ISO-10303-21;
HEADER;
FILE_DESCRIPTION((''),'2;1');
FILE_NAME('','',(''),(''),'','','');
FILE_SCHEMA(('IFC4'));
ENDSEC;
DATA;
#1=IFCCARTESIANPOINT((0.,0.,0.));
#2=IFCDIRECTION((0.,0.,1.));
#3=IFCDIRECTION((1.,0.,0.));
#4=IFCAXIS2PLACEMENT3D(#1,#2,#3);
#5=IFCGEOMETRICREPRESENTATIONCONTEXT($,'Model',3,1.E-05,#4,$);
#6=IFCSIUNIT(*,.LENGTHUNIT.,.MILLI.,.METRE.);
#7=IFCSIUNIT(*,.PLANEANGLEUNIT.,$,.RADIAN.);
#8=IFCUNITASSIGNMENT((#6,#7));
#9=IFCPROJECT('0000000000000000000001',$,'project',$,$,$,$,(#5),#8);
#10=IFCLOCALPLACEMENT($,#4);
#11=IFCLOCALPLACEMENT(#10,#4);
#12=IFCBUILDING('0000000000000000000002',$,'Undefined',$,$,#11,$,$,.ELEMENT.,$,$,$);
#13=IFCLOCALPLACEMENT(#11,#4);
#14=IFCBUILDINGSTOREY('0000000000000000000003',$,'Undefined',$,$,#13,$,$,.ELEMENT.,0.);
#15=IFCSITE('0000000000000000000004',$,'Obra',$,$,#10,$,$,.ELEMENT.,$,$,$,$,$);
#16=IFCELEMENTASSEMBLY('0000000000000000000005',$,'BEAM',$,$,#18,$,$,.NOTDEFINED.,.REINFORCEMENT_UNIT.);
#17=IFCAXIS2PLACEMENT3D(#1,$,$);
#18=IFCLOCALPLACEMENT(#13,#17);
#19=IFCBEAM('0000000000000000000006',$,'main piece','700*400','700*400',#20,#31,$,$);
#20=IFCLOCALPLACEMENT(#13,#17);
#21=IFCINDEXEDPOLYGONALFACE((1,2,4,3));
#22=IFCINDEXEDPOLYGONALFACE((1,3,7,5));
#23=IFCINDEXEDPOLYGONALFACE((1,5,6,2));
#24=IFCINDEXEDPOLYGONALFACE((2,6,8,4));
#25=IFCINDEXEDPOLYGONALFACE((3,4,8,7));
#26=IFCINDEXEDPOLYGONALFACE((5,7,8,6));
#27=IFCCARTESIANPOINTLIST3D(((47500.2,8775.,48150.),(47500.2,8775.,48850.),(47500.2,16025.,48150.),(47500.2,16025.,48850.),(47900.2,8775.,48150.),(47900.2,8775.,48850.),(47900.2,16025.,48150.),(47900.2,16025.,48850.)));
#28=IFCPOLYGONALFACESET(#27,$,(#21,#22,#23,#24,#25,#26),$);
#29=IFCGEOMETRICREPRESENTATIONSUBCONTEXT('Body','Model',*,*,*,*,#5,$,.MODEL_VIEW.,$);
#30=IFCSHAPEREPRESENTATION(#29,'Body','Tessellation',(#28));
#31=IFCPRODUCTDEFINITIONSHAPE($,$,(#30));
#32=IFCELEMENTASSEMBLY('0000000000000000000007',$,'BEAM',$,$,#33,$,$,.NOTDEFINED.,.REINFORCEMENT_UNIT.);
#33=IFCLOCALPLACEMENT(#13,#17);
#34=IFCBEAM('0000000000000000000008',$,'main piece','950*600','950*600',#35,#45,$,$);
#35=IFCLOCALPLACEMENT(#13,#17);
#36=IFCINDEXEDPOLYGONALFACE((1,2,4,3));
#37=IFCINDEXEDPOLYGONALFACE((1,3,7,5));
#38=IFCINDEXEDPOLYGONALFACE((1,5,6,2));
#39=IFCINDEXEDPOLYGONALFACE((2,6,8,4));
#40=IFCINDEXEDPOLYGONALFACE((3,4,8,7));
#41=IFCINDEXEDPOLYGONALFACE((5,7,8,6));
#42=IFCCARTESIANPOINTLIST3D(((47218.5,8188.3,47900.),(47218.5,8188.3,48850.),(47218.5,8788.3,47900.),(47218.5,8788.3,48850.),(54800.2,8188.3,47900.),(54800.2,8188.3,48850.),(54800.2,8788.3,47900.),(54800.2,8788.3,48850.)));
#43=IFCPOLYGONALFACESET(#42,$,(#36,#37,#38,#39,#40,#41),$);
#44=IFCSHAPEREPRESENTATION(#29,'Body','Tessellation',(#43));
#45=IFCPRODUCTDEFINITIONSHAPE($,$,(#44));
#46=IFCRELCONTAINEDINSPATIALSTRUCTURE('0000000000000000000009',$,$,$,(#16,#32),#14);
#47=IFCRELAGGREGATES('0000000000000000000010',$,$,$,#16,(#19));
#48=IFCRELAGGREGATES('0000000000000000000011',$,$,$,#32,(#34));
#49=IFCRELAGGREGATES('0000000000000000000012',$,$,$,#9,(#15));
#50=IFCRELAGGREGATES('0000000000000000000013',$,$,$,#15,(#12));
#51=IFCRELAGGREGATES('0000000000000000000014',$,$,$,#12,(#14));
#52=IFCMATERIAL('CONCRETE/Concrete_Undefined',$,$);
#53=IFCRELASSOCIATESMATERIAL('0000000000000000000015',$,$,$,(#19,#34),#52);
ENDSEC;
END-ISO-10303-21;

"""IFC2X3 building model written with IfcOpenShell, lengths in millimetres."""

from ifc_helpers import new_model, si_unit, frame, origin_with_axes, origin_2d_with_axis, place, context, subcontext, project, spatial, rectangle, extrude, material, element, aggregate, save


model = new_model("IFC2X3")

# Units and contexts
model_context = context("Model", 3, precision=1e-05, world=origin_with_axes())
body_context = subcontext(model_context, "Body", "Model", "MODEL_VIEW")
ifc_project = project(units=[si_unit("LENGTHUNIT", "METRE", prefix="MILLI"), si_unit("PLANEANGLEUNIT", "RADIAN")], contexts=[model_context])

# Site, building, storey
site_placement = place(None, origin_with_axes())
site = spatial("IfcSite", under=ifc_project, at=site_placement, Name="Obra", CompositionType="ELEMENT")
building_placement = place(site_placement, origin_with_axes())
building = spatial("IfcBuilding", under=site, at=building_placement, Name="Undefined", CompositionType="ELEMENT")
storey_placement = place(building_placement, origin_with_axes())
storey = spatial("IfcBuildingStorey", under=building, at=storey_placement, Name="Undefined", CompositionType="ELEMENT", Elevation=0.0)

# Shared definitions
ifc_material_1 = material(Name="CONCRETE/Concrete_Undefined")

# Element assemblies, beams
assembly_1_placement = place(storey_placement, origin_with_axes())
assembly_1 = element("IfcElementAssembly", 1, at=assembly_1_placement, inside=storey, Name="BEAM", AssemblyPlace="NOTDEFINED", PredefinedType="REINFORCEMENT_UNIT")
beam_1_placement = place(assembly_1_placement, frame((47700.2, 8775.0, 48500.0), z_axis=(0.0, 0.0, 1.0), x_axis=(-0.000002, 1.0, 0.0)))
beam_1 = element("IfcBeam", 2, at=beam_1_placement, material=ifc_material_1, Name="main piece", Description="700*400", ObjectType="700*400", context=body_context, shape_type="SweptSolid", body=[
    extrude(rectangle(XDim=400.0, YDim=700.0, at=origin_2d_with_axis()), frame((7250.0, 0.0, 0.0), z_axis=(-1.0, 0.0, 0.0), x_axis=(0.0, -1.0, 0.0)), (0.0, 0.0, 1.0), 7250.0),
])
aggregate(assembly_1, [beam_1])
assembly_2_placement = place(storey_placement, origin_with_axes())
assembly_2 = element("IfcElementAssembly", 3, at=assembly_2_placement, inside=storey, Name="BEAM", AssemblyPlace="NOTDEFINED", PredefinedType="REINFORCEMENT_UNIT")
beam_2_placement = place(assembly_2_placement, frame((47218.5, 8488.3, 48375.0), z_axis=(0.0, 0.0, 1.0), x_axis=(1.0, 0.0, 0.0)))
beam_2 = element("IfcBeam", 4, at=beam_2_placement, material=ifc_material_1, Name="main piece", Description="950*600", ObjectType="950*600", context=body_context, shape_type="SweptSolid", body=[
    extrude(rectangle(XDim=600.0, YDim=950.0, at=origin_2d_with_axis()), frame((7581.7, 0.0, 0.0), z_axis=(-1.0, 0.0, 0.0), x_axis=(0.0, -1.0, 0.0)), (0.0, 0.0, 1.0), 7581.7),
])
aggregate(assembly_2, [beam_2])

save(model, "model.ifc")
